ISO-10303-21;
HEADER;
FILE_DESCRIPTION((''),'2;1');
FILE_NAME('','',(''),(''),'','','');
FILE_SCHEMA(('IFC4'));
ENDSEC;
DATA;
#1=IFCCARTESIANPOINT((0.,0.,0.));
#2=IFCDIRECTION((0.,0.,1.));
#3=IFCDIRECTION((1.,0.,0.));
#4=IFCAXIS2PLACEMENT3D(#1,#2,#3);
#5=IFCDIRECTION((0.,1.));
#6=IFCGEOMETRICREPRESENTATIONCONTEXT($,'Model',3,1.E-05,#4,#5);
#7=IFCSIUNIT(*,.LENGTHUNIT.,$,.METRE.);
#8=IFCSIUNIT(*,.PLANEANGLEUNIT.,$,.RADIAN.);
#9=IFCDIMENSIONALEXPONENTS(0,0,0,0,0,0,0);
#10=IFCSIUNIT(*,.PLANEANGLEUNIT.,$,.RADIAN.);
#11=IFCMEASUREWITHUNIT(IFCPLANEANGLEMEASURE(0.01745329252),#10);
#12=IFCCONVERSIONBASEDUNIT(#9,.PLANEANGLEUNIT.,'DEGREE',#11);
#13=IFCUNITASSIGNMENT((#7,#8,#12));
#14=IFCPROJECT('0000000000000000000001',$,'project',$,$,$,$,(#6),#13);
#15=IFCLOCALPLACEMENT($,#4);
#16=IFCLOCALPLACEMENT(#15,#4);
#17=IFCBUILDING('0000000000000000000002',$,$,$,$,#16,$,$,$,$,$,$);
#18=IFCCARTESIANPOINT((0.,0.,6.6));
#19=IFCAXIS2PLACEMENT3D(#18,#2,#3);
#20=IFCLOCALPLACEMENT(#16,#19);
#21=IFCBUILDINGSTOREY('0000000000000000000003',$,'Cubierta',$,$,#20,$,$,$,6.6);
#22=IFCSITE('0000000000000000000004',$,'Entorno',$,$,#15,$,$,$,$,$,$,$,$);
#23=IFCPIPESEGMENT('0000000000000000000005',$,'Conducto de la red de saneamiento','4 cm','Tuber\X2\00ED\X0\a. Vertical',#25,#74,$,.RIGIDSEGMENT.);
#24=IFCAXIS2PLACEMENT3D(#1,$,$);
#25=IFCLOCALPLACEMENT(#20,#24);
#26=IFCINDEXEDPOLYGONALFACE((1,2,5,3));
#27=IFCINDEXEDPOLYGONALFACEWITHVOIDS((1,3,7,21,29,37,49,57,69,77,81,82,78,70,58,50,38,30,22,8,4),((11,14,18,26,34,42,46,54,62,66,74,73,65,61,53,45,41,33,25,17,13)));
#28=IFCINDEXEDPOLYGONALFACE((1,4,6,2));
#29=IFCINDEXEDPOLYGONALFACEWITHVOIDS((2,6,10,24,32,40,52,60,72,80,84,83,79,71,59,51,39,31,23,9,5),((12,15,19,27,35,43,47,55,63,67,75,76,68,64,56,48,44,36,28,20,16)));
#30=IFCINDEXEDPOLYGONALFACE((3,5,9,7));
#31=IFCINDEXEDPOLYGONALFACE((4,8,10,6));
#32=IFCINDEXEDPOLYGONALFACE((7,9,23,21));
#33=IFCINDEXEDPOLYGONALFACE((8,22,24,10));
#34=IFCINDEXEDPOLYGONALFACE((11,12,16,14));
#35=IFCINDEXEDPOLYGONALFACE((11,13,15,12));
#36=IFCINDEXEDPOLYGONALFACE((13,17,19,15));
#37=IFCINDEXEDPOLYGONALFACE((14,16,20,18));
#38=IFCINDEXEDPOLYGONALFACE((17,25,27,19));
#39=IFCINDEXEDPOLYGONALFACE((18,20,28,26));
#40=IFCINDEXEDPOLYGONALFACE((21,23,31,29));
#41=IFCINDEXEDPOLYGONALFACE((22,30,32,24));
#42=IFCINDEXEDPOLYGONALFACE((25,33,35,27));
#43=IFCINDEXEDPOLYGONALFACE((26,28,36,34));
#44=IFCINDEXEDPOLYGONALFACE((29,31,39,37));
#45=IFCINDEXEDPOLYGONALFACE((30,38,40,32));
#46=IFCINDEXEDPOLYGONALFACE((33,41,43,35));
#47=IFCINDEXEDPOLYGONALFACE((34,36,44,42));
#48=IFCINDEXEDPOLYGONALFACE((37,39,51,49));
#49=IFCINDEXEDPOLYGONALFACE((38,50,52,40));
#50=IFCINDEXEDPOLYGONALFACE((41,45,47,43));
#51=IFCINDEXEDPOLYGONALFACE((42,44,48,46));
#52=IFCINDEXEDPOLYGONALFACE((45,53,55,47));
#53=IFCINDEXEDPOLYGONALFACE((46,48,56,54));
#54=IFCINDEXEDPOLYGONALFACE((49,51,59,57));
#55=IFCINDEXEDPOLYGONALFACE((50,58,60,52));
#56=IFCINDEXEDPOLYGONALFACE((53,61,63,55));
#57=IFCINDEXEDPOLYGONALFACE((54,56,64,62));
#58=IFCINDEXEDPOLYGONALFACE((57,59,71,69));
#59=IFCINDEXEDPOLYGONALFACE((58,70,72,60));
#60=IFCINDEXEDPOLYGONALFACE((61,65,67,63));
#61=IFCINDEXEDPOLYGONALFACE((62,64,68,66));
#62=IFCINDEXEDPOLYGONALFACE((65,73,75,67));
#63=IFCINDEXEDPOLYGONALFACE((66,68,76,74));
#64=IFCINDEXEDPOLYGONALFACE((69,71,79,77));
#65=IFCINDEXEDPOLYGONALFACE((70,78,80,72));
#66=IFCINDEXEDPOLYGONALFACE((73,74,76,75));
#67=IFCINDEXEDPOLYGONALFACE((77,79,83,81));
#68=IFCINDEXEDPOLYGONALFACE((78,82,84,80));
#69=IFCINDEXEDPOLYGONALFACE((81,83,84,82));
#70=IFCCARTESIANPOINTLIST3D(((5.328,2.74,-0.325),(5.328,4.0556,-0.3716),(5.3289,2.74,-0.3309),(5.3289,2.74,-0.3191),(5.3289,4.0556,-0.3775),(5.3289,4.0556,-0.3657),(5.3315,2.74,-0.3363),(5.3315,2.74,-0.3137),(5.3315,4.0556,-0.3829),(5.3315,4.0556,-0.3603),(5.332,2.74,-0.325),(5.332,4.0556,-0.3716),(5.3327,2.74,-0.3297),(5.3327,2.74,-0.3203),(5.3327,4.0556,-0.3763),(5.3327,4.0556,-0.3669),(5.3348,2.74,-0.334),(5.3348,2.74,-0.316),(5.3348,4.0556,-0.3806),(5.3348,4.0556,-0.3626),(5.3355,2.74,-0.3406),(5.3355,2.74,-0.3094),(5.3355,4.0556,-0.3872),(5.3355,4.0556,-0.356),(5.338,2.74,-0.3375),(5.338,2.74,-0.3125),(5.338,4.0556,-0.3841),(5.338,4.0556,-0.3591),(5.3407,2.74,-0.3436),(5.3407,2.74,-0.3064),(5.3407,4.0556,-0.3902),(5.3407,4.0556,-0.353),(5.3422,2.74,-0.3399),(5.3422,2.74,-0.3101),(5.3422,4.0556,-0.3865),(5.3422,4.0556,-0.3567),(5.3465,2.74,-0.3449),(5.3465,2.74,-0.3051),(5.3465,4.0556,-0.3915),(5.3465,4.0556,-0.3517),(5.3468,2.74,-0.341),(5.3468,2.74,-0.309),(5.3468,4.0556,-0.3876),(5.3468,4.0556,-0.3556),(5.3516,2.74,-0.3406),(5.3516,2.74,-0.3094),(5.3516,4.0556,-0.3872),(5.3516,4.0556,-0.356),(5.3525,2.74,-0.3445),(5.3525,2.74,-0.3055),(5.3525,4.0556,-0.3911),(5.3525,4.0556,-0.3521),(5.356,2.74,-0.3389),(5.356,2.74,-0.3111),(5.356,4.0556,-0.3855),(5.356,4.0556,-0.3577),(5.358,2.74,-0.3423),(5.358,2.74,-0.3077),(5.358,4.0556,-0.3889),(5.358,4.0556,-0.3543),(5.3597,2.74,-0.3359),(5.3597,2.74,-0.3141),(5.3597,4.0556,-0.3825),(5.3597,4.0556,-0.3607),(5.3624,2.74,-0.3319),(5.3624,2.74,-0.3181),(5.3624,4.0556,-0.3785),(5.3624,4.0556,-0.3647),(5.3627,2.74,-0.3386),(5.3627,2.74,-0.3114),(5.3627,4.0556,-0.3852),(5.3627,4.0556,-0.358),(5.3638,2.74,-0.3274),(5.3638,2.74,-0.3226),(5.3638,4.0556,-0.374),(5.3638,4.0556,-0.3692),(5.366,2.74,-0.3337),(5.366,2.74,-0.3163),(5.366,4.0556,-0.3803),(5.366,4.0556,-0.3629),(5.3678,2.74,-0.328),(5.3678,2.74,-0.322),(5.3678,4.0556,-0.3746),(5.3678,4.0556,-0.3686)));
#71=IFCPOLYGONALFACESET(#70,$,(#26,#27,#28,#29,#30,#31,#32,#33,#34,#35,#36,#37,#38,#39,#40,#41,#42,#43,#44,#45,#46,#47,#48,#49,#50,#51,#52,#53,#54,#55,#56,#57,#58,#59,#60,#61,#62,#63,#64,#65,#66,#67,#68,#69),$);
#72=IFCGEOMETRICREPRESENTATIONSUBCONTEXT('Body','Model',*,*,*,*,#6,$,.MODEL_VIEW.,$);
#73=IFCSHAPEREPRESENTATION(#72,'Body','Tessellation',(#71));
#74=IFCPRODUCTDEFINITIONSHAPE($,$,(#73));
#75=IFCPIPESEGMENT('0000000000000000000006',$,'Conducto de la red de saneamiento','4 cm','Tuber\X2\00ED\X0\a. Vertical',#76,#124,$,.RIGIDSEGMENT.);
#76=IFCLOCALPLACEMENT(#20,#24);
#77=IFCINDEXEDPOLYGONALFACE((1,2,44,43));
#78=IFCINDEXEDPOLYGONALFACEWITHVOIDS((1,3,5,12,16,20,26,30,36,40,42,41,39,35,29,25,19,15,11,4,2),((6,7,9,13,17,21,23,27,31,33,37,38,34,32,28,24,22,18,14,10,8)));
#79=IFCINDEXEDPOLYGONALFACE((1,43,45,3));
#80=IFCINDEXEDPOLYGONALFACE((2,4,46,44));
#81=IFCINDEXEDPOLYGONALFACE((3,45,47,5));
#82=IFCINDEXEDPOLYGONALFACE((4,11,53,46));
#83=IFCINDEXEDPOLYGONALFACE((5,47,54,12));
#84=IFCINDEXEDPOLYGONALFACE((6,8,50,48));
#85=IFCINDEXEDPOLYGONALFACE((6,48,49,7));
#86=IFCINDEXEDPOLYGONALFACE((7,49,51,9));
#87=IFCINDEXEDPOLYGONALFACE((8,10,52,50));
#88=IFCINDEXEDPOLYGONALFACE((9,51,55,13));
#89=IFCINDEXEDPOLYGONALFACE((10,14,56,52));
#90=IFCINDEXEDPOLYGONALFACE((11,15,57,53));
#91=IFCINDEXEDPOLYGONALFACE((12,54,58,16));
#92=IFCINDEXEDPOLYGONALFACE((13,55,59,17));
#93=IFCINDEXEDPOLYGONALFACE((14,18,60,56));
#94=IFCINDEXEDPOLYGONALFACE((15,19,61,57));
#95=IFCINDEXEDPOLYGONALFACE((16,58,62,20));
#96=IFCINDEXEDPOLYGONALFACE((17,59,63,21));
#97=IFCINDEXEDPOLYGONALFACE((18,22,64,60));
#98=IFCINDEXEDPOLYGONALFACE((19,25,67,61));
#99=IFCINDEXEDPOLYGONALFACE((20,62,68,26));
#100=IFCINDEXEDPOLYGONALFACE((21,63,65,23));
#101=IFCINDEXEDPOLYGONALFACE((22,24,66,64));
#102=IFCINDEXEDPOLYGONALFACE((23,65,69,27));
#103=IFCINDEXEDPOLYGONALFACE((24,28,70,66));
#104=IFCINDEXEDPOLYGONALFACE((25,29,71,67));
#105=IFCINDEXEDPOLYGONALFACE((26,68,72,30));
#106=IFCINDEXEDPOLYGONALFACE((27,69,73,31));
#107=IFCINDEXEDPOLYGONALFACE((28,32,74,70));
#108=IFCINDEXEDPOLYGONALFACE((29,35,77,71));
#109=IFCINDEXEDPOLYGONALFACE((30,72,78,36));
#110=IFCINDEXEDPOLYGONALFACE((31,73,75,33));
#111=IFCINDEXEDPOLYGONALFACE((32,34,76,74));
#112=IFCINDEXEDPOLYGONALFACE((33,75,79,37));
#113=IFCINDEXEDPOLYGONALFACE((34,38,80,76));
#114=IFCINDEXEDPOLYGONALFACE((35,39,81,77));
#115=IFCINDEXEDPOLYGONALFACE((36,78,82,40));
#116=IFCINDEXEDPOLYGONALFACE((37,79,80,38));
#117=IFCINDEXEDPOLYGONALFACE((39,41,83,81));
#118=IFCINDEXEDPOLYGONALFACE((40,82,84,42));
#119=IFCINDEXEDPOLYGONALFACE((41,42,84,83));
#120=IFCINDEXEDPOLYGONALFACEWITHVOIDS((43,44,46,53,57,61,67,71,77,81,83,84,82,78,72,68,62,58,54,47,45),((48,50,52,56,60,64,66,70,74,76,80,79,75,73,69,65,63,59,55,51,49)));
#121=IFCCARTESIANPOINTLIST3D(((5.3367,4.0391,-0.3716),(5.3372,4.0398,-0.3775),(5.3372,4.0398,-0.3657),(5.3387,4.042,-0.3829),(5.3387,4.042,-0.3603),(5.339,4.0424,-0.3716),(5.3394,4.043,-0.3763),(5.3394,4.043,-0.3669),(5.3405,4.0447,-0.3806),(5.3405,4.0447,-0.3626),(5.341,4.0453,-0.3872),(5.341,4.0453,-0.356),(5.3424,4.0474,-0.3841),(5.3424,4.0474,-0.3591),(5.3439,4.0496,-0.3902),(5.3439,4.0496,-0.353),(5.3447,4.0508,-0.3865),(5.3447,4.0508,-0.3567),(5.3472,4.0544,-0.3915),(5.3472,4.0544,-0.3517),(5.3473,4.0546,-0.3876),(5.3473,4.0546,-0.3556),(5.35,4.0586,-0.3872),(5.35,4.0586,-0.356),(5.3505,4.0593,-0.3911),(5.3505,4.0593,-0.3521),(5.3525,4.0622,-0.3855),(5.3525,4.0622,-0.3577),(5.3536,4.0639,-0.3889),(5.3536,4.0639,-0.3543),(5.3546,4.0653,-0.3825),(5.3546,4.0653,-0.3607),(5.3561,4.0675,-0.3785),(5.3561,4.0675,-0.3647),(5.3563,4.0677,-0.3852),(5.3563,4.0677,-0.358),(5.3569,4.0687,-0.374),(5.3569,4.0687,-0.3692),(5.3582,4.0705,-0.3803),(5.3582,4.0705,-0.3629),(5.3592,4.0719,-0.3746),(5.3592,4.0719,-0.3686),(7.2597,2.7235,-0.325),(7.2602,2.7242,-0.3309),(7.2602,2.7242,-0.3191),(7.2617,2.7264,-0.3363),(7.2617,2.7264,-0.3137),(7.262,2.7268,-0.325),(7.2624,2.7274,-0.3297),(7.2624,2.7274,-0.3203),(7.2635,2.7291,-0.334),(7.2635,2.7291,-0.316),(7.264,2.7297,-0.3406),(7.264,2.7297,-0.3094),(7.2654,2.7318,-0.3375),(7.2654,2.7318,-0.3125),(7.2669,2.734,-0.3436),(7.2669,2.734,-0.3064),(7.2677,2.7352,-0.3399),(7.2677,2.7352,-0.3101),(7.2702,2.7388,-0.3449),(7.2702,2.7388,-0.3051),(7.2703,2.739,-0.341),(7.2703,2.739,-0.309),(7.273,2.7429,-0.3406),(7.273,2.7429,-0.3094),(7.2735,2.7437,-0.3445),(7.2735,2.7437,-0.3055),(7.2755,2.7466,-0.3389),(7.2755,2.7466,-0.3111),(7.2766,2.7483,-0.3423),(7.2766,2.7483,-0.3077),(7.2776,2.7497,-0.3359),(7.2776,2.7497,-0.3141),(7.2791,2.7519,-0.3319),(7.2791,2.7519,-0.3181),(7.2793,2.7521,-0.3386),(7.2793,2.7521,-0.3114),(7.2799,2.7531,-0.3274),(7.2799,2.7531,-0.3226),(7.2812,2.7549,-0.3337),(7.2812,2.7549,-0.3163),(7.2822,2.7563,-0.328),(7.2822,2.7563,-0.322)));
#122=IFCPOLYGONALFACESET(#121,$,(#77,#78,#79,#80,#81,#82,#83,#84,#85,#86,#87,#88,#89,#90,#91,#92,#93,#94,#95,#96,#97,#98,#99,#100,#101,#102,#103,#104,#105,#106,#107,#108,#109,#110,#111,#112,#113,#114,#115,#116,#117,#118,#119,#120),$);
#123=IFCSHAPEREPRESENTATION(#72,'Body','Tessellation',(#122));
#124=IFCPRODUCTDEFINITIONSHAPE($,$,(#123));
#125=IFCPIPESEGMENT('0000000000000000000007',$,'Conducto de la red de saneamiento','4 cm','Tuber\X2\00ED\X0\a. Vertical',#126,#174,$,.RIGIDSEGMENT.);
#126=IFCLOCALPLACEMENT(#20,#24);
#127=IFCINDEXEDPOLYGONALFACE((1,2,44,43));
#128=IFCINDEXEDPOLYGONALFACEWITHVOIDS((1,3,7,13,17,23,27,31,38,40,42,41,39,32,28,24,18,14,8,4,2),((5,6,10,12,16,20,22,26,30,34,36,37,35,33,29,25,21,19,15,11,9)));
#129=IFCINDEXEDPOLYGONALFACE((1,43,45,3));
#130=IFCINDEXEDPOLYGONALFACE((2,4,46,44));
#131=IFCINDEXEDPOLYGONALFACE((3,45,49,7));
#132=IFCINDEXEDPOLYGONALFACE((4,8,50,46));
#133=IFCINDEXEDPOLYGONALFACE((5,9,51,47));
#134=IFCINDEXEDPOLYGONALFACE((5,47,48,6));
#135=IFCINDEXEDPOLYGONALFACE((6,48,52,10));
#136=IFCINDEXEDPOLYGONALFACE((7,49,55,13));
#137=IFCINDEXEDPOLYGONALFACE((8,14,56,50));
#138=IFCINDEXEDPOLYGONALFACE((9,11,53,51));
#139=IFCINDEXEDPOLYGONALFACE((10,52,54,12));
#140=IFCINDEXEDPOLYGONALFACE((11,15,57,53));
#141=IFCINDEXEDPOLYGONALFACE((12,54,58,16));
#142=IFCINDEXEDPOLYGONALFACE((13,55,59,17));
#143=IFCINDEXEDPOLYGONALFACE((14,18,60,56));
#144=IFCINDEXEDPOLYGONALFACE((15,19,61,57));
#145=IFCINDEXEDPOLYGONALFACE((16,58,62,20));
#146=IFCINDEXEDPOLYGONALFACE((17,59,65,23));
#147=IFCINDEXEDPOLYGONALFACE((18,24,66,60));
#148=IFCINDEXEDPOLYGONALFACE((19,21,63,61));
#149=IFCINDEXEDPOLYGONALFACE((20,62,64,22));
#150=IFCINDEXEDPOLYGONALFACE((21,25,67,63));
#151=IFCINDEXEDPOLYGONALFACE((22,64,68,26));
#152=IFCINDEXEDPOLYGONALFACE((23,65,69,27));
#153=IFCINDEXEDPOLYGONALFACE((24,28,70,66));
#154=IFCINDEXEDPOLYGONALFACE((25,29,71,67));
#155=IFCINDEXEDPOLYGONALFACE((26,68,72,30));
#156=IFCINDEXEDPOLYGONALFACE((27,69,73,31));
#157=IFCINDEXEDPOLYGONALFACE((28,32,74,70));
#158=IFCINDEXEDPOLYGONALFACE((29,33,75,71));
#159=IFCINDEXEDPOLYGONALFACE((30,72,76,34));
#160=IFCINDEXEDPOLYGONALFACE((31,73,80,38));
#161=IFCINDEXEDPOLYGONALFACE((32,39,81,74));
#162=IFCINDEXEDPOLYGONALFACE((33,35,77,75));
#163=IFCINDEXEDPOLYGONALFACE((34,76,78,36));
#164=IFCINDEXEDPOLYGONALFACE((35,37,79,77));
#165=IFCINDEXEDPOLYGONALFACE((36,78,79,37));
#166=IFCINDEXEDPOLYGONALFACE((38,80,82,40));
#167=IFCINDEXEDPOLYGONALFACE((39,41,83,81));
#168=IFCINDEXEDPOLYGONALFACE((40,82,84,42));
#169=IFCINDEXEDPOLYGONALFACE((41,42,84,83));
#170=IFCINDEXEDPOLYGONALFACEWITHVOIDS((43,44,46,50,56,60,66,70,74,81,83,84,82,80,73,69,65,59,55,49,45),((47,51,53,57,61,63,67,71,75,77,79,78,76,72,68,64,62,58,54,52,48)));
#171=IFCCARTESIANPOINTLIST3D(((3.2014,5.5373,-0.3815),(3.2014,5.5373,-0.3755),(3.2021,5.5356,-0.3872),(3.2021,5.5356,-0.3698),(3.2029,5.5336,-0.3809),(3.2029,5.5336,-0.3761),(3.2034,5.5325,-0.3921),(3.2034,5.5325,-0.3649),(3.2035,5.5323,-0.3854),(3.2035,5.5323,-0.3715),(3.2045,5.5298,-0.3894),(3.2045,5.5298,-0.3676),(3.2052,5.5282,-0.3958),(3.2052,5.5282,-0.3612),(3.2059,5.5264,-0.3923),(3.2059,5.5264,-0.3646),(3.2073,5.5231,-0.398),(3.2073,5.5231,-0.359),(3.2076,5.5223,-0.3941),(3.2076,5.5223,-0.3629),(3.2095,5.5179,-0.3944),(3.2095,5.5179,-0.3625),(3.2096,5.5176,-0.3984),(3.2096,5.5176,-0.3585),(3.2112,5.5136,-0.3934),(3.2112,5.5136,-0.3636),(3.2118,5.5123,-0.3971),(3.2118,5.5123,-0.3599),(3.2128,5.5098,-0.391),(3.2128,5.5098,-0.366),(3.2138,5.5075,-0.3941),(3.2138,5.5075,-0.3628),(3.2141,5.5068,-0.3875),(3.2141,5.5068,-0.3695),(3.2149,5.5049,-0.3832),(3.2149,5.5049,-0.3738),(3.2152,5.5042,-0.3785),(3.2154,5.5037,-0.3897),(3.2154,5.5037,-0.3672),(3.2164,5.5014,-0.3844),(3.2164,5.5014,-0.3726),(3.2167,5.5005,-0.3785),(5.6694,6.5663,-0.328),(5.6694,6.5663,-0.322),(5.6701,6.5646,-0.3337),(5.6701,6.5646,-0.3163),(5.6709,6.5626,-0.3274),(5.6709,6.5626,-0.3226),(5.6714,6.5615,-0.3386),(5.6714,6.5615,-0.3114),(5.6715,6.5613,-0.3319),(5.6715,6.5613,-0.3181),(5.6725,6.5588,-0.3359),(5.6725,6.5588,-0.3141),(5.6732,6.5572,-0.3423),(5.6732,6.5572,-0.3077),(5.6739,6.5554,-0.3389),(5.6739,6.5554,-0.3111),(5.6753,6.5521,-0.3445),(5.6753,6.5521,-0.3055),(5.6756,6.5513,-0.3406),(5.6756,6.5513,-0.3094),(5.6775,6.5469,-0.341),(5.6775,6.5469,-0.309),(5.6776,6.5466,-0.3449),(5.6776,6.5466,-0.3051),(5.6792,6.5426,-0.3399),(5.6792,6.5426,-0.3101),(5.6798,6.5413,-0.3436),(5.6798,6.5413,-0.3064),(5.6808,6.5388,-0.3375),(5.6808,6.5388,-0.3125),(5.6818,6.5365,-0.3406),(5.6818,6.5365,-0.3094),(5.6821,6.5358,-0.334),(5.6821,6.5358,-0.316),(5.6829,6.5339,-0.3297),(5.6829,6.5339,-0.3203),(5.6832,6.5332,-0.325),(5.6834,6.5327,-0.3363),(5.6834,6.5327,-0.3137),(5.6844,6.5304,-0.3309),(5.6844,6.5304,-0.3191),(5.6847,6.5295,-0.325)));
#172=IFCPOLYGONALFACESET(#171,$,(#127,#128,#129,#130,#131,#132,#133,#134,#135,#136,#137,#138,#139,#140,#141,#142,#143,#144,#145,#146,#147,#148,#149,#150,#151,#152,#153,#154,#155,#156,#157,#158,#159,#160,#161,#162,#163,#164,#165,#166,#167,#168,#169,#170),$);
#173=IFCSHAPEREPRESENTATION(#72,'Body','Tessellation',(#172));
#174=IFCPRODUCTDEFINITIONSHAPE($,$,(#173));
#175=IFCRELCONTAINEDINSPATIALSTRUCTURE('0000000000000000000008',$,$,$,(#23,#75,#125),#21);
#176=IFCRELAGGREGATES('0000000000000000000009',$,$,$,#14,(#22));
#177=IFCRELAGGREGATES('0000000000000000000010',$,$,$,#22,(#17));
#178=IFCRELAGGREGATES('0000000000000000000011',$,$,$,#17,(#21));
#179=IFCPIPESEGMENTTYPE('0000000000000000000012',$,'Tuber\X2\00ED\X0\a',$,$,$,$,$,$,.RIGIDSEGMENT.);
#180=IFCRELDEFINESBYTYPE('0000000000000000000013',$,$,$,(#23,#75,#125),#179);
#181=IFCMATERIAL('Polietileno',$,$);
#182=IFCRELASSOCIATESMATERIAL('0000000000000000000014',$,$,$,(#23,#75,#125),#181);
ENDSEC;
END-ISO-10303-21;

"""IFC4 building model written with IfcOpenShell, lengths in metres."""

from ifc_helpers import new_model, entity, si_unit, converted_unit, direction, frame, origin_with_axes, origin_2d_with_axis, place, context, subcontext, project, spatial, hollow_circle, extrude, material, type_object, element, save


model = new_model("IFC4")

# Units and contexts
model_context = context("Model", 3, precision=1e-05, world=origin_with_axes(), true_north=direction((0.0, 1.0)))
body_context = subcontext(model_context, "Body", "Model", "MODEL_VIEW")
ifc_project = project(units=[si_unit("LENGTHUNIT", "METRE"), si_unit("PLANEANGLEUNIT", "RADIAN"), converted_unit("PLANEANGLEUNIT", "DEGREE", entity("IfcPlaneAngleMeasure", 0.01745329252), si_unit("PLANEANGLEUNIT", "RADIAN"), dimensions=[0, 0, 0, 0, 0, 0, 0])], contexts=[model_context])

# Site, building, storey
site_placement = place(None, origin_with_axes())
site = spatial("IfcSite", under=ifc_project, at=site_placement, Name="Entorno")
building_placement = place(site_placement, origin_with_axes())
building = spatial("IfcBuilding", under=site, at=building_placement)
storey_placement = place(building_placement, frame((0.0, 0.0, 6.6), z_axis=(0.0, 0.0, 1.0), x_axis=(1.0, 0.0, 0.0)))
storey = spatial("IfcBuildingStorey", under=building, at=storey_placement, Name="Cubierta", Elevation=6.6)

# Pipe segments
ifc_material_1 = material(Name="Polietileno")
pipe_segment_type_1 = type_object("IfcPipeSegmentType", Name="Tubería", PredefinedType="RIGIDSEGMENT")
pipe_segment_1_placement = place(storey_placement, frame((5.348, 2.74, -0.325), z_axis=(0.0, 1.0, 0.0), x_axis=(-1.0, 0.0, 0.0)))
element("IfcPipeSegment", 1, at=pipe_segment_1_placement, inside=storey, type_object=pipe_segment_type_1, material=ifc_material_1, Name="Conducto de la red de saneamiento", Description="4 cm", ObjectType="Tubería. Vertical", PredefinedType="RIGIDSEGMENT", context=body_context, shape_type="SweptSolid", body=[
    extrude(hollow_circle(Radius=0.02, WallThickness=0.004, at=origin_2d_with_axis()), origin_with_axes(), (0.0, -0.035398, 0.999373), 1.3164),
])
pipe_segment_2_placement = place(storey_placement, frame((7.271, 2.74, -0.325), z_axis=(-0.825332, 0.564647, 0.0), x_axis=(-0.564647, -0.825332, 0.0)))
element("IfcPipeSegment", 2, at=pipe_segment_2_placement, inside=storey, type_object=pipe_segment_type_1, material=ifc_material_1, Name="Conducto de la red de saneamiento", Description="4 cm", ObjectType="Tubería. Vertical", PredefinedType="RIGIDSEGMENT", context=body_context, shape_type="SweptSolid", body=[
    extrude(hollow_circle(Radius=0.02, WallThickness=0.004, at=origin_2d_with_axis()), origin_with_axes(), (0.0, -0.019996, 0.9998), 2.3304),
])
pipe_segment_3_placement = place(storey_placement, frame((5.677, 6.548, -0.325), z_axis=(-0.922988, -0.384828, 0.0), x_axis=(0.384828, -0.922988, 0.0)))
element("IfcPipeSegment", 3, at=pipe_segment_3_placement, inside=storey, type_object=pipe_segment_type_1, material=ifc_material_1, Name="Conducto de la red de saneamiento", Description="4 cm", ObjectType="Tubería. Vertical", PredefinedType="RIGIDSEGMENT", context=body_context, shape_type="SweptSolid", body=[
    extrude(hollow_circle(Radius=0.02, WallThickness=0.004, at=origin_2d_with_axis()), origin_with_axes(), (0.0, -0.019996, 0.9998), 2.6745),
])

save(model, "model.ifc")
